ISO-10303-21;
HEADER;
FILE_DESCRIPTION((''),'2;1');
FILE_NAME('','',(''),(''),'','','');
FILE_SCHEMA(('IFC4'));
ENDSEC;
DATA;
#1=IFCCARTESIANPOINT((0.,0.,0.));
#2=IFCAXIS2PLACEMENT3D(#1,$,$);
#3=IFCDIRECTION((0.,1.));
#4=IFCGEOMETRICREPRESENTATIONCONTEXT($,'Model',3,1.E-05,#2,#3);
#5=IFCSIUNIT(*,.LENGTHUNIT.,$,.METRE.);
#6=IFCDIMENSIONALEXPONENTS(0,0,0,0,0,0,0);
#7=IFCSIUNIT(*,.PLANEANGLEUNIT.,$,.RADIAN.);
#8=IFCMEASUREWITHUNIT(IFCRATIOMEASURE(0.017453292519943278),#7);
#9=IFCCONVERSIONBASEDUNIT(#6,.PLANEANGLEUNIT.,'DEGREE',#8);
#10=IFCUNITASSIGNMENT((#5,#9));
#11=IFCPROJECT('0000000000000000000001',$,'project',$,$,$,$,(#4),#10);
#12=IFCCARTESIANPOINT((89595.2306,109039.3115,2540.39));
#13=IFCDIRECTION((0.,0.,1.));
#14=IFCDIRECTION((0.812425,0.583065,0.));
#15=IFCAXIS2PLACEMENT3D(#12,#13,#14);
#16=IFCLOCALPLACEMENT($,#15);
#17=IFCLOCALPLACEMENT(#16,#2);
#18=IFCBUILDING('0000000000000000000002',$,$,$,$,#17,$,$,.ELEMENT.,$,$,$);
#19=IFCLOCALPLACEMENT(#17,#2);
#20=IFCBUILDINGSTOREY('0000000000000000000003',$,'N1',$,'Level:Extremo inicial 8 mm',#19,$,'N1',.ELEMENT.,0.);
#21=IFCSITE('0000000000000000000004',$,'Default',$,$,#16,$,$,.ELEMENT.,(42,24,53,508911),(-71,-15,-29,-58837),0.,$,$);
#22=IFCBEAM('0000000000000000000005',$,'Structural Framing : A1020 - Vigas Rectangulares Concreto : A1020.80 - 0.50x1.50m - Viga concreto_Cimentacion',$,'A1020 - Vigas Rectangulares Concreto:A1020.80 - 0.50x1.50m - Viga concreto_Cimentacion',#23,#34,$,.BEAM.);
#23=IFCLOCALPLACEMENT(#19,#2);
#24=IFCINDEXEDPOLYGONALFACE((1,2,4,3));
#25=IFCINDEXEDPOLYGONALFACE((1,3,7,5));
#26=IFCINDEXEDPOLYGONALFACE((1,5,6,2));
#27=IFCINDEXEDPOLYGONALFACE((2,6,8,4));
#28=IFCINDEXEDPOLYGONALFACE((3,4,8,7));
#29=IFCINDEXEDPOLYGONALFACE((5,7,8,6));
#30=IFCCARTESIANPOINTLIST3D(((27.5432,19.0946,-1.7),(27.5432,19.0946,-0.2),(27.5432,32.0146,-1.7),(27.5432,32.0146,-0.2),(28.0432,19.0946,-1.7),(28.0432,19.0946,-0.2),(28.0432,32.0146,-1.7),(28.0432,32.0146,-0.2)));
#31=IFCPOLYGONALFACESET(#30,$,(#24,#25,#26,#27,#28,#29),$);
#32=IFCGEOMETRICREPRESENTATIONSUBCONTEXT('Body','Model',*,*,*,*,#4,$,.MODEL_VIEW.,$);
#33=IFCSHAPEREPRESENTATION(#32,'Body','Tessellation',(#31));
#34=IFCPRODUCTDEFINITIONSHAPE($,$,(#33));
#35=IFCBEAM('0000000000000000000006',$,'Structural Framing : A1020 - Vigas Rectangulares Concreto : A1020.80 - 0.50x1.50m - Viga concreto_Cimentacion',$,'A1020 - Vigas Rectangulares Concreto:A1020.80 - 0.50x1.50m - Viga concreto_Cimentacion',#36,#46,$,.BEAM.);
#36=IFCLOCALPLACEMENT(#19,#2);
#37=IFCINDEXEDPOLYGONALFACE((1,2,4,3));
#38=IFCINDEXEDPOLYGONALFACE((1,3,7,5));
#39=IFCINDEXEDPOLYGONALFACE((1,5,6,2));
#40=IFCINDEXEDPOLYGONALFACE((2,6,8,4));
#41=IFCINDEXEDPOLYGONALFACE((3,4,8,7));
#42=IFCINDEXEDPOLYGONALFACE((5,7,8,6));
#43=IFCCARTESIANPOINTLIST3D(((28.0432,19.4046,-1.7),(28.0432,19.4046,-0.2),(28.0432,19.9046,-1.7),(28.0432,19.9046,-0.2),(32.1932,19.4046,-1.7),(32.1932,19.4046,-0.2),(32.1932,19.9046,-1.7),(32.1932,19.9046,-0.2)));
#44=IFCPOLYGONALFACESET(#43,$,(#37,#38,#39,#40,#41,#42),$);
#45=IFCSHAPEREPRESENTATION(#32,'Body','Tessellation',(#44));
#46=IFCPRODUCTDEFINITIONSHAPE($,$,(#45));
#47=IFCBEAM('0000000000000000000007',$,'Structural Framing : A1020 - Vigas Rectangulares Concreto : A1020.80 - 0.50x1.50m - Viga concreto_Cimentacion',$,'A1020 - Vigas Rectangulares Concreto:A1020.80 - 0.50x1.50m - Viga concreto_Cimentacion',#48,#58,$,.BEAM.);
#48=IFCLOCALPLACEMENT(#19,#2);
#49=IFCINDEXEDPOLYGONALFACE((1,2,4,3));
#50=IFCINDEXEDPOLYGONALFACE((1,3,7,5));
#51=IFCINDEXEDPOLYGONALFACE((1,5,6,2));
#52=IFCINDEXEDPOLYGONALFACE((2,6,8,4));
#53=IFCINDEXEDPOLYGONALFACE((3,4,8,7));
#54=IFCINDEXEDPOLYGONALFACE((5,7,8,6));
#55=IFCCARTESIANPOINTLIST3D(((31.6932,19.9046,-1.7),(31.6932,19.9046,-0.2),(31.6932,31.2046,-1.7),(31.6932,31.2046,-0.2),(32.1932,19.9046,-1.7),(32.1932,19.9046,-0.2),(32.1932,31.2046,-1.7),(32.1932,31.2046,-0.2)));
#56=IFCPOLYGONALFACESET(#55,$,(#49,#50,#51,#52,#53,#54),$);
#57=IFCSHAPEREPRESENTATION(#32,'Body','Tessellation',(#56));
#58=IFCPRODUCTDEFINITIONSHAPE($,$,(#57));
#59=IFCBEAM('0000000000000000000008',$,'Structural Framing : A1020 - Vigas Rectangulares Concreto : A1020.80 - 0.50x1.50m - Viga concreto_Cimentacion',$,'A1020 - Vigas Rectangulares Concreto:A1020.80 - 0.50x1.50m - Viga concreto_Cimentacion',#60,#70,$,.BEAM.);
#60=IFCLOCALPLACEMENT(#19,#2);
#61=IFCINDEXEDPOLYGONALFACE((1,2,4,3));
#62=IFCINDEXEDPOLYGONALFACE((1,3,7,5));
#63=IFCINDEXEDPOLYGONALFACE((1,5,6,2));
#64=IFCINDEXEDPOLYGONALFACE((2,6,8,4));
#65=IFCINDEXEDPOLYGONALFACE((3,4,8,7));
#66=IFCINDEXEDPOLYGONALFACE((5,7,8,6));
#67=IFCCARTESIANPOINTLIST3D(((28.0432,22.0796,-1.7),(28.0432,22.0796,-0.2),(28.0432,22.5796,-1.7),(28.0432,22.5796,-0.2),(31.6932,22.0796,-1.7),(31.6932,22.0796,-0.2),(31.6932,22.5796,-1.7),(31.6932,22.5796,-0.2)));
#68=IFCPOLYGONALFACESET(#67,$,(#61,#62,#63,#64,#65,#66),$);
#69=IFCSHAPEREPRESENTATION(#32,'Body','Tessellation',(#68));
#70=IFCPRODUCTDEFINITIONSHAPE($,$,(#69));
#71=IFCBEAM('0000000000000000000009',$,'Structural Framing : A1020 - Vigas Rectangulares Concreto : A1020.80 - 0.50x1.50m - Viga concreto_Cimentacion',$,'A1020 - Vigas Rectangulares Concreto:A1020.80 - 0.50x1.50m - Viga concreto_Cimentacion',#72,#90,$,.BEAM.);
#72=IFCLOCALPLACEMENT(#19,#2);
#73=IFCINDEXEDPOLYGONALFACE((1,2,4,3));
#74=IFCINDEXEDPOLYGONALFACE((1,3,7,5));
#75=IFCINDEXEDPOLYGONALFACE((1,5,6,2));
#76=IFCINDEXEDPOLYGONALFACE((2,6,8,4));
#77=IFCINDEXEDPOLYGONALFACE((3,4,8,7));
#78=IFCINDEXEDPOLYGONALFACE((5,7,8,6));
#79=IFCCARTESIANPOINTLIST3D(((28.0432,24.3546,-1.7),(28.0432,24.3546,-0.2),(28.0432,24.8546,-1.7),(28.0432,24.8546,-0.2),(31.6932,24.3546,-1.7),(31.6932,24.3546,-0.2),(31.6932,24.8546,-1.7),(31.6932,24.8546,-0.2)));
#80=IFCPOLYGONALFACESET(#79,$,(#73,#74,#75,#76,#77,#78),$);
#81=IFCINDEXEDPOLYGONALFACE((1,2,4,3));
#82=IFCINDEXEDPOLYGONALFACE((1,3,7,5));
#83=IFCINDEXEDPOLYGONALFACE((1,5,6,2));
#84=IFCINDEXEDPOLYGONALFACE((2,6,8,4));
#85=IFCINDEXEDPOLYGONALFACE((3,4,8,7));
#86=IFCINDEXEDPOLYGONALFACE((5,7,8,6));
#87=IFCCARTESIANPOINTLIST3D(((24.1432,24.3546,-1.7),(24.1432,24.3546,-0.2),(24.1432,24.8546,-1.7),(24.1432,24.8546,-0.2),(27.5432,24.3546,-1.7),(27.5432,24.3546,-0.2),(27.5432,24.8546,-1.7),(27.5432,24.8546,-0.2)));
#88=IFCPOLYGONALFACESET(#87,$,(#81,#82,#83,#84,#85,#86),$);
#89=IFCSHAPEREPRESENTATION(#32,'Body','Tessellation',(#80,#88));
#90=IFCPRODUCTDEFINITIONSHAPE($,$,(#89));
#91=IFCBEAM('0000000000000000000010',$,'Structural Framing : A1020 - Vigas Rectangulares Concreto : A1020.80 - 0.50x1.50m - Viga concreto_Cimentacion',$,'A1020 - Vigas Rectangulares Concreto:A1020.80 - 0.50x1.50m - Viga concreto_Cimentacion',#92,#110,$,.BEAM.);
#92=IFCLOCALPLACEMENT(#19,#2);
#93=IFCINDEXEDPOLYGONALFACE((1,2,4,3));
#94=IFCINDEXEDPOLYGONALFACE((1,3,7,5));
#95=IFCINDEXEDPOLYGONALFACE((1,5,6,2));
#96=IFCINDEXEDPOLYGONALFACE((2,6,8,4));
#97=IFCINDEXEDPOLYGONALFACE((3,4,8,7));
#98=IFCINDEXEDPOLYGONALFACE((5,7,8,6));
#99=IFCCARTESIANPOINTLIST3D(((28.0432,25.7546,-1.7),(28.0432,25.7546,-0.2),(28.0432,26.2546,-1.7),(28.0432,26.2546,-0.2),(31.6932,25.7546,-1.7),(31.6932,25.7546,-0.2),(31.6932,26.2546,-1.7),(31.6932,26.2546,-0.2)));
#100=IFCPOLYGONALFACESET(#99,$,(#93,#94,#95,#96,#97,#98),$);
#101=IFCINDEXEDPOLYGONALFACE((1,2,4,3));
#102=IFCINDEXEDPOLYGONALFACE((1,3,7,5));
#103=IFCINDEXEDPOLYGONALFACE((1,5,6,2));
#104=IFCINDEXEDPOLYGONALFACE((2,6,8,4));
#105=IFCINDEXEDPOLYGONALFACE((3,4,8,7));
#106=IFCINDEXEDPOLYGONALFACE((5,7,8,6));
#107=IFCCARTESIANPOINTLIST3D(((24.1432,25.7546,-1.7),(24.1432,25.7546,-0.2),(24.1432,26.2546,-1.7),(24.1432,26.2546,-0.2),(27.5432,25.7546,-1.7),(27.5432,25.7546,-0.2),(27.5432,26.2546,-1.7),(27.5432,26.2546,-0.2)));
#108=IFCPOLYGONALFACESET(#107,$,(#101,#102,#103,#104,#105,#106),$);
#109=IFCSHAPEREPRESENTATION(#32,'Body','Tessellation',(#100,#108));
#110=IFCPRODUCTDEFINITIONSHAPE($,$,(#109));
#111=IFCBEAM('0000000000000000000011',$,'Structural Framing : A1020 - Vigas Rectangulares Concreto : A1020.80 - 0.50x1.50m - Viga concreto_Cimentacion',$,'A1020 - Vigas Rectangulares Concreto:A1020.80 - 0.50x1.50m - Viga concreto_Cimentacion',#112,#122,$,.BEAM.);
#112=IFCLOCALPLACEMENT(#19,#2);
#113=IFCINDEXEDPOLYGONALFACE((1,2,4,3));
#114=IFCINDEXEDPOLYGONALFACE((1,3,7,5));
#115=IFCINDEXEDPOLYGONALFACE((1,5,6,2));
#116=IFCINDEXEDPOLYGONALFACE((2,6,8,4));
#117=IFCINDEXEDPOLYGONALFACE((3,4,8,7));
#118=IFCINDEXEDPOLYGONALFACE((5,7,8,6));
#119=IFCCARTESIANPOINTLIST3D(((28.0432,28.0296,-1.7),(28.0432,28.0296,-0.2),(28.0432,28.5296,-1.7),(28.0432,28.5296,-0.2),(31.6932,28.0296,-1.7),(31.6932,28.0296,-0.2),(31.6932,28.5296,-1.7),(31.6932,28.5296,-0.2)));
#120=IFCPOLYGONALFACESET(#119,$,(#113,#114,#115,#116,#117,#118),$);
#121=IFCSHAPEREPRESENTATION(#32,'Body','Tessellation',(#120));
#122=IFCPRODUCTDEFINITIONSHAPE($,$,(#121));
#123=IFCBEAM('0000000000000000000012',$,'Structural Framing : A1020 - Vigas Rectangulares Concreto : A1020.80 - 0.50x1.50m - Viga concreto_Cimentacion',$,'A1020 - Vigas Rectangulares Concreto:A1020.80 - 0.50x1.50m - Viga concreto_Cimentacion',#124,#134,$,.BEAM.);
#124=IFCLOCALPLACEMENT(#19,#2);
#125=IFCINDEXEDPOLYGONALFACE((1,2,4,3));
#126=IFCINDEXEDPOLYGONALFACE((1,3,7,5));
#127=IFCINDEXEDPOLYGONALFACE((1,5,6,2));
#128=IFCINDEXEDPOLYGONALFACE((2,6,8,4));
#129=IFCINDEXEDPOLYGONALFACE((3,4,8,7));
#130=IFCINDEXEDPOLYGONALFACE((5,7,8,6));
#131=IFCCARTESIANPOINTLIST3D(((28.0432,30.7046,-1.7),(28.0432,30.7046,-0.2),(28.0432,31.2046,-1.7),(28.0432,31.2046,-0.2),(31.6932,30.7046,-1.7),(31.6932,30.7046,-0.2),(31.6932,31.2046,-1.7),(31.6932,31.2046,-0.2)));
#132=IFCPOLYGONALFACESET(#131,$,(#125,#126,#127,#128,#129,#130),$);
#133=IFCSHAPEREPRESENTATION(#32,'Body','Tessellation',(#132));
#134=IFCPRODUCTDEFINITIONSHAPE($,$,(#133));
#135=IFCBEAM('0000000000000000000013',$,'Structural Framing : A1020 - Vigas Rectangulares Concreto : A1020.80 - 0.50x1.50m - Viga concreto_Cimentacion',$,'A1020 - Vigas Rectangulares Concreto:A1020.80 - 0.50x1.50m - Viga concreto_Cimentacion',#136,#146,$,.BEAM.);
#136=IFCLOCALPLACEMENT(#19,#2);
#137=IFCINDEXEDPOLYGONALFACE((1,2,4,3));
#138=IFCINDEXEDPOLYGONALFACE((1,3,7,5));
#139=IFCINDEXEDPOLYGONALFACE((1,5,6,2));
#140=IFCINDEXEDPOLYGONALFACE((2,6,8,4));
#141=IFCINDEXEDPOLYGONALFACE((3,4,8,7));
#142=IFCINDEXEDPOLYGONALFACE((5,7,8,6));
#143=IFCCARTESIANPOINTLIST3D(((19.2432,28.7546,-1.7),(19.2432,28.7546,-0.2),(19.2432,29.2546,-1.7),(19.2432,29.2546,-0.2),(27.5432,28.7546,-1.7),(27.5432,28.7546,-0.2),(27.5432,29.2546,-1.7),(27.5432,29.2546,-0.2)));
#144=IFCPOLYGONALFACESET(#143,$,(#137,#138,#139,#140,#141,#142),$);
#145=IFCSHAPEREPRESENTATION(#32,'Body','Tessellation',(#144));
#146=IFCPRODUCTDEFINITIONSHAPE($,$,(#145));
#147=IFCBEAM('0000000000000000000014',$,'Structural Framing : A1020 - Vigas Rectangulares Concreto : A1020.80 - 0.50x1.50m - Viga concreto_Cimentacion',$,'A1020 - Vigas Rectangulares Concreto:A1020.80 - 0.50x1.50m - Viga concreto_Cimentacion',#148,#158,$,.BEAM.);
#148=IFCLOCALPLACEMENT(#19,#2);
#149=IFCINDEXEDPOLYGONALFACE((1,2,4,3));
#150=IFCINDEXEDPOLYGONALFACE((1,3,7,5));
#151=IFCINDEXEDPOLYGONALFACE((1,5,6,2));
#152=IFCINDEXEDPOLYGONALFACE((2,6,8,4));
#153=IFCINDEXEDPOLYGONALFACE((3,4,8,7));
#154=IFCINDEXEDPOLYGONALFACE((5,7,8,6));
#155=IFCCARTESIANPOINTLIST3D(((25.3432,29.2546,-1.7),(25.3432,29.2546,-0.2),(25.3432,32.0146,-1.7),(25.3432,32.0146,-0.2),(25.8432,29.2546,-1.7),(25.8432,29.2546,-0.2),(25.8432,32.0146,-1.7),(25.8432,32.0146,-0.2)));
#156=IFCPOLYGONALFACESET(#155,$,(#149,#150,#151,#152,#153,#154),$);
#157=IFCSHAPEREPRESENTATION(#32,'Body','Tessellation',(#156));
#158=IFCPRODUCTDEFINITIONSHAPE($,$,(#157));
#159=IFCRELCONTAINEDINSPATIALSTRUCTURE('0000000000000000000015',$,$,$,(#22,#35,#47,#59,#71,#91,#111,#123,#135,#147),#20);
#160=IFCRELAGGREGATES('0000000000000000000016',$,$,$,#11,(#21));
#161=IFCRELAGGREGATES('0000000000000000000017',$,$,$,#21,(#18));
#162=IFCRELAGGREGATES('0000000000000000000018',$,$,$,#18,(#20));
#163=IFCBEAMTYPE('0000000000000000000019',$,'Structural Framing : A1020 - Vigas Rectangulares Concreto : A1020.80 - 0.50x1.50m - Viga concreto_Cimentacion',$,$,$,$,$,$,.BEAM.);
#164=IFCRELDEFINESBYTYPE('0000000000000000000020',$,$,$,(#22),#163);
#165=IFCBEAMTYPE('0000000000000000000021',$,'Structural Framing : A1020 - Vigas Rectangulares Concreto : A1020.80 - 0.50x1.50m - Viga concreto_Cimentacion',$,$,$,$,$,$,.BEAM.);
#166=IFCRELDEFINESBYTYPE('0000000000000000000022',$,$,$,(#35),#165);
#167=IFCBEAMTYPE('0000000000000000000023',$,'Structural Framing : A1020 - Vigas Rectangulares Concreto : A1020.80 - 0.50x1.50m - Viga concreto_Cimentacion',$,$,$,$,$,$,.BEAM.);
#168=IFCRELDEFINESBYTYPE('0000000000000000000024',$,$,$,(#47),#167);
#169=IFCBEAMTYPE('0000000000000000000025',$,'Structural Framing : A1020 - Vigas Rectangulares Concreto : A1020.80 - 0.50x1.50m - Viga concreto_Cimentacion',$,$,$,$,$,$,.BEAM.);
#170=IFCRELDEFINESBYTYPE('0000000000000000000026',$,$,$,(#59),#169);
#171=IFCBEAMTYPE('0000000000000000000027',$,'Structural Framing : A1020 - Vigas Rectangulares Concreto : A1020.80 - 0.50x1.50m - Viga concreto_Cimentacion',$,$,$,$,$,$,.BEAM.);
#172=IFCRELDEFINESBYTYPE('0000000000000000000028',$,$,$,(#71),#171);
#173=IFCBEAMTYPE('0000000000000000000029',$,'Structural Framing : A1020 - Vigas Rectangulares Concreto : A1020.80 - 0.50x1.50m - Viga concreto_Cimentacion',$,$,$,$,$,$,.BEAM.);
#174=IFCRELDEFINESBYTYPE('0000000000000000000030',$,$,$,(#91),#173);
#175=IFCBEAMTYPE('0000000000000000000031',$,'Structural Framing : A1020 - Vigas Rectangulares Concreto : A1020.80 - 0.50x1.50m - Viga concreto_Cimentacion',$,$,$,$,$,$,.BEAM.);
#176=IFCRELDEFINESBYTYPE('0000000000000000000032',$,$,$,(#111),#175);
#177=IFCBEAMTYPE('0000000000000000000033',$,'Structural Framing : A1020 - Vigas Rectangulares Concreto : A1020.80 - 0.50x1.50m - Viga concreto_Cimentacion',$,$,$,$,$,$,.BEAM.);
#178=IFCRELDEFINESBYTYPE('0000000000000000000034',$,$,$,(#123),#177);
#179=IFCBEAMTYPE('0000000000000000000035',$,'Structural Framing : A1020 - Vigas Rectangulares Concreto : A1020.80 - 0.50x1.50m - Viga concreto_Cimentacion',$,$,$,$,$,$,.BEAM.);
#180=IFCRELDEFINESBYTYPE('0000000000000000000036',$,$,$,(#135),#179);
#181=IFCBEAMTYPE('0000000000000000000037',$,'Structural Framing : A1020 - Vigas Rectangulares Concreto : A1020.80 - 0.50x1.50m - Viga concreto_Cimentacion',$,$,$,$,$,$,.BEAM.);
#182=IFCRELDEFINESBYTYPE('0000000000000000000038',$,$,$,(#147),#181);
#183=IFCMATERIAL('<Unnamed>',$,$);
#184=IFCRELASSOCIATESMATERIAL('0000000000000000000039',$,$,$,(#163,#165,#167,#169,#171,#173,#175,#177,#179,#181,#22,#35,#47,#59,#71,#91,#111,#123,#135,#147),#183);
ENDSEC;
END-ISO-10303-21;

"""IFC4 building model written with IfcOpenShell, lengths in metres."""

from ifc_helpers import new_model, entity, si_unit, converted_unit, direction, frame, frame_2d, origin, place, context, subcontext, project, spatial, polyline, segment, composite_curve, rectangle, outline, extrude, source, transform, mapped, material, material_profile, profile_set, profile_usage, type_object, type_shapes, element, save


model = new_model("IFC4")

# Units and contexts
model_context = context("Model", 3, precision=1e-05, world=origin(), true_north=direction((0.0, 1.0)))
body_context = subcontext(model_context, "Body", "Model", "MODEL_VIEW")
ifc_project = project(units=[si_unit("LENGTHUNIT", "METRE"), converted_unit("PLANEANGLEUNIT", "DEGREE", entity("IfcRatioMeasure", 0.017453292519943278), si_unit("PLANEANGLEUNIT", "RADIAN"), dimensions=[0, 0, 0, 0, 0, 0, 0])], contexts=[model_context])

# Site, building, storey
site_placement = place(None, frame((89595.2306, 109039.3115, 2540.39), z_axis=(0.0, 0.0, 1.0), x_axis=(0.812425, 0.583065, 0.0)))
site = spatial("IfcSite", under=ifc_project, at=site_placement, Name="Default", CompositionType="ELEMENT", RefLatitude=(42, 24, 53, 508911), RefLongitude=(-71, -15, -29, -58837), RefElevation=0.0)
building_placement = place(site_placement, origin())
building = spatial("IfcBuilding", under=site, at=building_placement, CompositionType="ELEMENT")
storey_placement = place(building_placement, origin())
storey = spatial("IfcBuildingStorey", under=building, at=storey_placement, Name="N1", ObjectType="Level:Extremo inicial 8 mm", LongName="N1", CompositionType="ELEMENT", Elevation=0.0)

# Beams
ifc_material = material(Name="<Unnamed>")
ifc_material_profile_1 = material_profile(ifc_material, outline(composite_curve([segment(polyline([(0.25, 0.75, 0.0), (0.25, -0.75, 0.0)]), True, "CONTINUOUS"), segment(polyline([(0.25, -0.75, 0.0), (-0.25, -0.75, 0.0)]), True, "CONTINUOUS"), segment(polyline([(-0.25, -0.75, 0.0), (-0.25, 0.75, 0.0)]), True, "CONTINUOUS"), segment(polyline([(-0.25, 0.75, 0.0), (0.25, 0.75, 0.0)]), True, "CONTINUOUS")], self_intersect=False), kind="CURVE"), Name="A1020.80 - 0.50x1.50m - Viga concreto_Cimentacion")
ifc_material_profile_2 = material_profile(ifc_material, outline(composite_curve([segment(polyline([(-5.3373, 0.25, 0.75), (-5.3373, 0.25, -0.75)]), True, "CONTINUOUS"), segment(polyline([(-5.3373, 0.25, -0.75), (-5.3373, -0.25, -0.75)]), True, "CONTINUOUS"), segment(polyline([(-5.3373, -0.25, -0.75), (-5.3373, -0.25, 0.75)]), True, "CONTINUOUS"), segment(polyline([(-5.3373, -0.25, 0.75), (-5.3373, 0.25, 0.75)]), True, "CONTINUOUS")], self_intersect=False), kind="CURVE"), Name="A1020.80 - 0.50x1.50m - Viga concreto_Cimentacion")
ifc_profile_set_1 = profile_set([ifc_material_profile_1, ifc_material_profile_2], Name="A1020.80 - 0.50x1.50m - Viga concreto_Cimentacion")
ifc_profile_usage_1 = profile_usage(ifc_profile_set_1, cardinal=8)
beam_type_1 = type_object("IfcBeamType", Name="Structural Framing : A1020 - Vigas Rectangulares Concreto : A1020.80 - 0.50x1.50m - Viga concreto_Cimentacion", PredefinedType="BEAM", material=ifc_profile_set_1)
shared_shape_1 = source(origin(), body_context, "Body", "SweptSolid", [
    extrude(rectangle(XDim=1.5, YDim=0.5, at=frame_2d((0.0, 0.0), x_axis=(0.0, 1.0))), frame((27.7932, 19.0946, -0.95), z_axis=(0.0, 1.0, 0.0), x_axis=(-1.0, 0.0, 0.0)), (0.0, 0.0, 1.0), 12.92),
])
type_shapes(beam_type_1, [shared_shape_1])
beam_1_placement = place(storey_placement, origin())
element("IfcBeam", 1, at=beam_1_placement, inside=storey, type_object=beam_type_1, material=ifc_profile_usage_1, Name="Structural Framing : A1020 - Vigas Rectangulares Concreto : A1020.80 - 0.50x1.50m - Viga concreto_Cimentacion", ObjectType="A1020 - Vigas Rectangulares Concreto:A1020.80 - 0.50x1.50m - Viga concreto_Cimentacion", PredefinedType="BEAM", context=body_context, shape_type="MappedRepresentation", body=[
    mapped(shared_shape_1, transform((0.0, 0.0, 0.0), scale=1.0)),
])
ifc_profile_usage_2 = profile_usage(ifc_profile_set_1, cardinal=8)
beam_type_2 = type_object("IfcBeamType", Name="Structural Framing : A1020 - Vigas Rectangulares Concreto : A1020.80 - 0.50x1.50m - Viga concreto_Cimentacion", PredefinedType="BEAM", material=ifc_profile_set_1)
shared_shape_2 = source(origin(), body_context, "Body", "SweptSolid", [
    extrude(rectangle(XDim=1.5, YDim=0.5, at=frame_2d((0.0, 0.0), x_axis=(1.0, 0.0))), frame((28.0432, 19.6546, -0.95), z_axis=(1.0, 0.0, 0.0), x_axis=(0.0, 0.0, -1.0)), (0.0, 0.0, 1.0), 4.15),
])
type_shapes(beam_type_2, [shared_shape_2])
beam_2_placement = place(storey_placement, origin())
element("IfcBeam", 2, at=beam_2_placement, inside=storey, type_object=beam_type_2, material=ifc_profile_usage_2, Name="Structural Framing : A1020 - Vigas Rectangulares Concreto : A1020.80 - 0.50x1.50m - Viga concreto_Cimentacion", ObjectType="A1020 - Vigas Rectangulares Concreto:A1020.80 - 0.50x1.50m - Viga concreto_Cimentacion", PredefinedType="BEAM", context=body_context, shape_type="MappedRepresentation", body=[
    mapped(shared_shape_2, transform((0.0, 0.0, 0.0), scale=1.0)),
])
ifc_profile_usage_3 = profile_usage(ifc_profile_set_1, cardinal=8)
beam_type_3 = type_object("IfcBeamType", Name="Structural Framing : A1020 - Vigas Rectangulares Concreto : A1020.80 - 0.50x1.50m - Viga concreto_Cimentacion", PredefinedType="BEAM", material=ifc_profile_set_1)
shared_shape_3 = source(origin(), body_context, "Body", "SweptSolid", [
    extrude(rectangle(XDim=1.5, YDim=0.5, at=frame_2d((0.0, 0.0), x_axis=(0.0, 1.0))), frame((31.9432, 19.9046, -0.95), z_axis=(0.0, 1.0, 0.0), x_axis=(-1.0, 0.0, 0.0)), (0.0, 0.0, 1.0), 11.3),
])
type_shapes(beam_type_3, [shared_shape_3])
beam_3_placement = place(storey_placement, origin())
element("IfcBeam", 3, at=beam_3_placement, inside=storey, type_object=beam_type_3, material=ifc_profile_usage_3, Name="Structural Framing : A1020 - Vigas Rectangulares Concreto : A1020.80 - 0.50x1.50m - Viga concreto_Cimentacion", ObjectType="A1020 - Vigas Rectangulares Concreto:A1020.80 - 0.50x1.50m - Viga concreto_Cimentacion", PredefinedType="BEAM", context=body_context, shape_type="MappedRepresentation", body=[
    mapped(shared_shape_3, transform((0.0, 0.0, 0.0), scale=1.0)),
])
ifc_profile_usage_4 = profile_usage(ifc_profile_set_1, cardinal=8)
beam_type_4 = type_object("IfcBeamType", Name="Structural Framing : A1020 - Vigas Rectangulares Concreto : A1020.80 - 0.50x1.50m - Viga concreto_Cimentacion", PredefinedType="BEAM", material=ifc_profile_set_1)
shared_shape_4 = source(origin(), body_context, "Body", "SweptSolid", [
    extrude(rectangle(XDim=1.5, YDim=0.5, at=frame_2d((0.0, 0.0), x_axis=(1.0, 0.0))), frame((31.6932, 22.3296, -0.95), z_axis=(-1.0, 0.0, 0.0), x_axis=(0.0, 0.0, -1.0)), (0.0, 0.0, 1.0), 3.65),
])
type_shapes(beam_type_4, [shared_shape_4])
beam_4_placement = place(storey_placement, origin())
element("IfcBeam", 4, at=beam_4_placement, inside=storey, type_object=beam_type_4, material=ifc_profile_usage_4, Name="Structural Framing : A1020 - Vigas Rectangulares Concreto : A1020.80 - 0.50x1.50m - Viga concreto_Cimentacion", ObjectType="A1020 - Vigas Rectangulares Concreto:A1020.80 - 0.50x1.50m - Viga concreto_Cimentacion", PredefinedType="BEAM", context=body_context, shape_type="MappedRepresentation", body=[
    mapped(shared_shape_4, transform((0.0, 0.0, 0.0), scale=1.0)),
])
ifc_profile_usage_5 = profile_usage(ifc_profile_set_1, cardinal=8)
beam_type_5 = type_object("IfcBeamType", Name="Structural Framing : A1020 - Vigas Rectangulares Concreto : A1020.80 - 0.50x1.50m - Viga concreto_Cimentacion", PredefinedType="BEAM", material=ifc_profile_set_1)
shared_shape_5 = source(origin(), body_context, "Body", "SweptSolid", [
    extrude(rectangle(XDim=1.5, YDim=0.5, at=frame_2d((0.0, 0.0), x_axis=(1.0, 0.0))), frame((31.6932, 24.6046, -0.95), z_axis=(-1.0, 0.0, 0.0), x_axis=(0.0, 0.0, -1.0)), (0.0, 0.0, 1.0), 3.65),
    extrude(rectangle(XDim=1.5, YDim=0.5, at=frame_2d((0.0, 0.0), x_axis=(1.0, 0.0))), frame((27.5432, 24.6046, -0.95), z_axis=(-1.0, 0.0, 0.0), x_axis=(0.0, 0.0, -1.0)), (0.0, 0.0, 1.0), 3.4),
])
type_shapes(beam_type_5, [shared_shape_5])
beam_5_placement = place(storey_placement, origin())
element("IfcBeam", 5, at=beam_5_placement, inside=storey, type_object=beam_type_5, material=ifc_profile_usage_5, Name="Structural Framing : A1020 - Vigas Rectangulares Concreto : A1020.80 - 0.50x1.50m - Viga concreto_Cimentacion", ObjectType="A1020 - Vigas Rectangulares Concreto:A1020.80 - 0.50x1.50m - Viga concreto_Cimentacion", PredefinedType="BEAM", context=body_context, shape_type="MappedRepresentation", body=[
    mapped(shared_shape_5, transform((0.0, 0.0, 0.0), scale=1.0)),
])
ifc_profile_usage_6 = profile_usage(ifc_profile_set_1, cardinal=8)
beam_type_6 = type_object("IfcBeamType", Name="Structural Framing : A1020 - Vigas Rectangulares Concreto : A1020.80 - 0.50x1.50m - Viga concreto_Cimentacion", PredefinedType="BEAM", material=ifc_profile_set_1)
shared_shape_6 = source(origin(), body_context, "Body", "SweptSolid", [
    extrude(rectangle(XDim=1.5, YDim=0.5, at=frame_2d((0.0, 0.0), x_axis=(1.0, 0.0))), frame((31.6932, 26.0046, -0.95), z_axis=(-1.0, 0.0, 0.0), x_axis=(0.0, 0.0, -1.0)), (0.0, 0.0, 1.0), 3.65),
    extrude(rectangle(XDim=1.5, YDim=0.5, at=frame_2d((0.0, 0.0), x_axis=(1.0, 0.0))), frame((27.5432, 26.0046, -0.95), z_axis=(-1.0, 0.0, 0.0), x_axis=(0.0, 0.0, -1.0)), (0.0, 0.0, 1.0), 3.4),
])
type_shapes(beam_type_6, [shared_shape_6])
beam_6_placement = place(storey_placement, origin())
element("IfcBeam", 6, at=beam_6_placement, inside=storey, type_object=beam_type_6, material=ifc_profile_usage_6, Name="Structural Framing : A1020 - Vigas Rectangulares Concreto : A1020.80 - 0.50x1.50m - Viga concreto_Cimentacion", ObjectType="A1020 - Vigas Rectangulares Concreto:A1020.80 - 0.50x1.50m - Viga concreto_Cimentacion", PredefinedType="BEAM", context=body_context, shape_type="MappedRepresentation", body=[
    mapped(shared_shape_6, transform((0.0, 0.0, 0.0), scale=1.0)),
])
ifc_profile_usage_7 = profile_usage(ifc_profile_set_1, cardinal=8)
beam_type_7 = type_object("IfcBeamType", Name="Structural Framing : A1020 - Vigas Rectangulares Concreto : A1020.80 - 0.50x1.50m - Viga concreto_Cimentacion", PredefinedType="BEAM", material=ifc_profile_set_1)
shared_shape_7 = source(origin(), body_context, "Body", "SweptSolid", [
    extrude(rectangle(XDim=1.5, YDim=0.5, at=frame_2d((0.0, 0.0), x_axis=(1.0, 0.0))), frame((31.6932, 28.2796, -0.95), z_axis=(-1.0, 0.0, 0.0), x_axis=(0.0, 0.0, -1.0)), (0.0, 0.0, 1.0), 3.65),
])
type_shapes(beam_type_7, [shared_shape_7])
beam_7_placement = place(storey_placement, origin())
element("IfcBeam", 7, at=beam_7_placement, inside=storey, type_object=beam_type_7, material=ifc_profile_usage_7, Name="Structural Framing : A1020 - Vigas Rectangulares Concreto : A1020.80 - 0.50x1.50m - Viga concreto_Cimentacion", ObjectType="A1020 - Vigas Rectangulares Concreto:A1020.80 - 0.50x1.50m - Viga concreto_Cimentacion", PredefinedType="BEAM", context=body_context, shape_type="MappedRepresentation", body=[
    mapped(shared_shape_7, transform((0.0, 0.0, 0.0), scale=1.0)),
])
ifc_profile_usage_8 = profile_usage(ifc_profile_set_1, cardinal=8)
beam_type_8 = type_object("IfcBeamType", Name="Structural Framing : A1020 - Vigas Rectangulares Concreto : A1020.80 - 0.50x1.50m - Viga concreto_Cimentacion", PredefinedType="BEAM", material=ifc_profile_set_1)
shared_shape_8 = source(origin(), body_context, "Body", "SweptSolid", [
    extrude(rectangle(XDim=1.5, YDim=0.5, at=frame_2d((0.0, 0.0), x_axis=(1.0, 0.0))), frame((31.6932, 30.9546, -0.95), z_axis=(-1.0, 0.0, 0.0), x_axis=(0.0, 0.0, -1.0)), (0.0, 0.0, 1.0), 3.65),
])
type_shapes(beam_type_8, [shared_shape_8])
beam_8_placement = place(storey_placement, origin())
element("IfcBeam", 8, at=beam_8_placement, inside=storey, type_object=beam_type_8, material=ifc_profile_usage_8, Name="Structural Framing : A1020 - Vigas Rectangulares Concreto : A1020.80 - 0.50x1.50m - Viga concreto_Cimentacion", ObjectType="A1020 - Vigas Rectangulares Concreto:A1020.80 - 0.50x1.50m - Viga concreto_Cimentacion", PredefinedType="BEAM", context=body_context, shape_type="MappedRepresentation", body=[
    mapped(shared_shape_8, transform((0.0, 0.0, 0.0), scale=1.0)),
])
ifc_profile_usage_9 = profile_usage(ifc_profile_set_1, cardinal=8)
beam_type_9 = type_object("IfcBeamType", Name="Structural Framing : A1020 - Vigas Rectangulares Concreto : A1020.80 - 0.50x1.50m - Viga concreto_Cimentacion", PredefinedType="BEAM", material=ifc_profile_set_1)
shared_shape_9 = source(origin(), body_context, "Body", "SweptSolid", [
    extrude(rectangle(XDim=1.5, YDim=0.5, at=frame_2d((0.0, 0.0), x_axis=(1.0, 0.0))), frame((27.5432, 29.0046, -0.95), z_axis=(-1.0, 0.0, 0.0), x_axis=(0.0, 0.0, -1.0)), (0.0, 0.0, 1.0), 8.3),
])
type_shapes(beam_type_9, [shared_shape_9])
beam_9_placement = place(storey_placement, origin())
element("IfcBeam", 9, at=beam_9_placement, inside=storey, type_object=beam_type_9, material=ifc_profile_usage_9, Name="Structural Framing : A1020 - Vigas Rectangulares Concreto : A1020.80 - 0.50x1.50m - Viga concreto_Cimentacion", ObjectType="A1020 - Vigas Rectangulares Concreto:A1020.80 - 0.50x1.50m - Viga concreto_Cimentacion", PredefinedType="BEAM", context=body_context, shape_type="MappedRepresentation", body=[
    mapped(shared_shape_9, transform((0.0, 0.0, 0.0), scale=1.0)),
])
ifc_profile_usage_10 = profile_usage(ifc_profile_set_1, cardinal=8)
beam_type_10 = type_object("IfcBeamType", Name="Structural Framing : A1020 - Vigas Rectangulares Concreto : A1020.80 - 0.50x1.50m - Viga concreto_Cimentacion", PredefinedType="BEAM", material=ifc_profile_set_1)
shared_shape_10 = source(origin(), body_context, "Body", "SweptSolid", [
    extrude(rectangle(XDim=1.5, YDim=0.5, at=frame_2d((0.0, 0.0), x_axis=(0.0, 1.0))), frame((25.5932, 29.2546, -0.95), z_axis=(0.0, 1.0, 0.0), x_axis=(-1.0, 0.0, 0.0)), (0.0, 0.0, 1.0), 2.76),
])
type_shapes(beam_type_10, [shared_shape_10])
beam_10_placement = place(storey_placement, origin())
element("IfcBeam", 10, at=beam_10_placement, inside=storey, type_object=beam_type_10, material=ifc_profile_usage_10, Name="Structural Framing : A1020 - Vigas Rectangulares Concreto : A1020.80 - 0.50x1.50m - Viga concreto_Cimentacion", ObjectType="A1020 - Vigas Rectangulares Concreto:A1020.80 - 0.50x1.50m - Viga concreto_Cimentacion", PredefinedType="BEAM", context=body_context, shape_type="MappedRepresentation", body=[
    mapped(shared_shape_10, transform((0.0, 0.0, 0.0), scale=1.0)),
])

save(model, "model.ifc")
